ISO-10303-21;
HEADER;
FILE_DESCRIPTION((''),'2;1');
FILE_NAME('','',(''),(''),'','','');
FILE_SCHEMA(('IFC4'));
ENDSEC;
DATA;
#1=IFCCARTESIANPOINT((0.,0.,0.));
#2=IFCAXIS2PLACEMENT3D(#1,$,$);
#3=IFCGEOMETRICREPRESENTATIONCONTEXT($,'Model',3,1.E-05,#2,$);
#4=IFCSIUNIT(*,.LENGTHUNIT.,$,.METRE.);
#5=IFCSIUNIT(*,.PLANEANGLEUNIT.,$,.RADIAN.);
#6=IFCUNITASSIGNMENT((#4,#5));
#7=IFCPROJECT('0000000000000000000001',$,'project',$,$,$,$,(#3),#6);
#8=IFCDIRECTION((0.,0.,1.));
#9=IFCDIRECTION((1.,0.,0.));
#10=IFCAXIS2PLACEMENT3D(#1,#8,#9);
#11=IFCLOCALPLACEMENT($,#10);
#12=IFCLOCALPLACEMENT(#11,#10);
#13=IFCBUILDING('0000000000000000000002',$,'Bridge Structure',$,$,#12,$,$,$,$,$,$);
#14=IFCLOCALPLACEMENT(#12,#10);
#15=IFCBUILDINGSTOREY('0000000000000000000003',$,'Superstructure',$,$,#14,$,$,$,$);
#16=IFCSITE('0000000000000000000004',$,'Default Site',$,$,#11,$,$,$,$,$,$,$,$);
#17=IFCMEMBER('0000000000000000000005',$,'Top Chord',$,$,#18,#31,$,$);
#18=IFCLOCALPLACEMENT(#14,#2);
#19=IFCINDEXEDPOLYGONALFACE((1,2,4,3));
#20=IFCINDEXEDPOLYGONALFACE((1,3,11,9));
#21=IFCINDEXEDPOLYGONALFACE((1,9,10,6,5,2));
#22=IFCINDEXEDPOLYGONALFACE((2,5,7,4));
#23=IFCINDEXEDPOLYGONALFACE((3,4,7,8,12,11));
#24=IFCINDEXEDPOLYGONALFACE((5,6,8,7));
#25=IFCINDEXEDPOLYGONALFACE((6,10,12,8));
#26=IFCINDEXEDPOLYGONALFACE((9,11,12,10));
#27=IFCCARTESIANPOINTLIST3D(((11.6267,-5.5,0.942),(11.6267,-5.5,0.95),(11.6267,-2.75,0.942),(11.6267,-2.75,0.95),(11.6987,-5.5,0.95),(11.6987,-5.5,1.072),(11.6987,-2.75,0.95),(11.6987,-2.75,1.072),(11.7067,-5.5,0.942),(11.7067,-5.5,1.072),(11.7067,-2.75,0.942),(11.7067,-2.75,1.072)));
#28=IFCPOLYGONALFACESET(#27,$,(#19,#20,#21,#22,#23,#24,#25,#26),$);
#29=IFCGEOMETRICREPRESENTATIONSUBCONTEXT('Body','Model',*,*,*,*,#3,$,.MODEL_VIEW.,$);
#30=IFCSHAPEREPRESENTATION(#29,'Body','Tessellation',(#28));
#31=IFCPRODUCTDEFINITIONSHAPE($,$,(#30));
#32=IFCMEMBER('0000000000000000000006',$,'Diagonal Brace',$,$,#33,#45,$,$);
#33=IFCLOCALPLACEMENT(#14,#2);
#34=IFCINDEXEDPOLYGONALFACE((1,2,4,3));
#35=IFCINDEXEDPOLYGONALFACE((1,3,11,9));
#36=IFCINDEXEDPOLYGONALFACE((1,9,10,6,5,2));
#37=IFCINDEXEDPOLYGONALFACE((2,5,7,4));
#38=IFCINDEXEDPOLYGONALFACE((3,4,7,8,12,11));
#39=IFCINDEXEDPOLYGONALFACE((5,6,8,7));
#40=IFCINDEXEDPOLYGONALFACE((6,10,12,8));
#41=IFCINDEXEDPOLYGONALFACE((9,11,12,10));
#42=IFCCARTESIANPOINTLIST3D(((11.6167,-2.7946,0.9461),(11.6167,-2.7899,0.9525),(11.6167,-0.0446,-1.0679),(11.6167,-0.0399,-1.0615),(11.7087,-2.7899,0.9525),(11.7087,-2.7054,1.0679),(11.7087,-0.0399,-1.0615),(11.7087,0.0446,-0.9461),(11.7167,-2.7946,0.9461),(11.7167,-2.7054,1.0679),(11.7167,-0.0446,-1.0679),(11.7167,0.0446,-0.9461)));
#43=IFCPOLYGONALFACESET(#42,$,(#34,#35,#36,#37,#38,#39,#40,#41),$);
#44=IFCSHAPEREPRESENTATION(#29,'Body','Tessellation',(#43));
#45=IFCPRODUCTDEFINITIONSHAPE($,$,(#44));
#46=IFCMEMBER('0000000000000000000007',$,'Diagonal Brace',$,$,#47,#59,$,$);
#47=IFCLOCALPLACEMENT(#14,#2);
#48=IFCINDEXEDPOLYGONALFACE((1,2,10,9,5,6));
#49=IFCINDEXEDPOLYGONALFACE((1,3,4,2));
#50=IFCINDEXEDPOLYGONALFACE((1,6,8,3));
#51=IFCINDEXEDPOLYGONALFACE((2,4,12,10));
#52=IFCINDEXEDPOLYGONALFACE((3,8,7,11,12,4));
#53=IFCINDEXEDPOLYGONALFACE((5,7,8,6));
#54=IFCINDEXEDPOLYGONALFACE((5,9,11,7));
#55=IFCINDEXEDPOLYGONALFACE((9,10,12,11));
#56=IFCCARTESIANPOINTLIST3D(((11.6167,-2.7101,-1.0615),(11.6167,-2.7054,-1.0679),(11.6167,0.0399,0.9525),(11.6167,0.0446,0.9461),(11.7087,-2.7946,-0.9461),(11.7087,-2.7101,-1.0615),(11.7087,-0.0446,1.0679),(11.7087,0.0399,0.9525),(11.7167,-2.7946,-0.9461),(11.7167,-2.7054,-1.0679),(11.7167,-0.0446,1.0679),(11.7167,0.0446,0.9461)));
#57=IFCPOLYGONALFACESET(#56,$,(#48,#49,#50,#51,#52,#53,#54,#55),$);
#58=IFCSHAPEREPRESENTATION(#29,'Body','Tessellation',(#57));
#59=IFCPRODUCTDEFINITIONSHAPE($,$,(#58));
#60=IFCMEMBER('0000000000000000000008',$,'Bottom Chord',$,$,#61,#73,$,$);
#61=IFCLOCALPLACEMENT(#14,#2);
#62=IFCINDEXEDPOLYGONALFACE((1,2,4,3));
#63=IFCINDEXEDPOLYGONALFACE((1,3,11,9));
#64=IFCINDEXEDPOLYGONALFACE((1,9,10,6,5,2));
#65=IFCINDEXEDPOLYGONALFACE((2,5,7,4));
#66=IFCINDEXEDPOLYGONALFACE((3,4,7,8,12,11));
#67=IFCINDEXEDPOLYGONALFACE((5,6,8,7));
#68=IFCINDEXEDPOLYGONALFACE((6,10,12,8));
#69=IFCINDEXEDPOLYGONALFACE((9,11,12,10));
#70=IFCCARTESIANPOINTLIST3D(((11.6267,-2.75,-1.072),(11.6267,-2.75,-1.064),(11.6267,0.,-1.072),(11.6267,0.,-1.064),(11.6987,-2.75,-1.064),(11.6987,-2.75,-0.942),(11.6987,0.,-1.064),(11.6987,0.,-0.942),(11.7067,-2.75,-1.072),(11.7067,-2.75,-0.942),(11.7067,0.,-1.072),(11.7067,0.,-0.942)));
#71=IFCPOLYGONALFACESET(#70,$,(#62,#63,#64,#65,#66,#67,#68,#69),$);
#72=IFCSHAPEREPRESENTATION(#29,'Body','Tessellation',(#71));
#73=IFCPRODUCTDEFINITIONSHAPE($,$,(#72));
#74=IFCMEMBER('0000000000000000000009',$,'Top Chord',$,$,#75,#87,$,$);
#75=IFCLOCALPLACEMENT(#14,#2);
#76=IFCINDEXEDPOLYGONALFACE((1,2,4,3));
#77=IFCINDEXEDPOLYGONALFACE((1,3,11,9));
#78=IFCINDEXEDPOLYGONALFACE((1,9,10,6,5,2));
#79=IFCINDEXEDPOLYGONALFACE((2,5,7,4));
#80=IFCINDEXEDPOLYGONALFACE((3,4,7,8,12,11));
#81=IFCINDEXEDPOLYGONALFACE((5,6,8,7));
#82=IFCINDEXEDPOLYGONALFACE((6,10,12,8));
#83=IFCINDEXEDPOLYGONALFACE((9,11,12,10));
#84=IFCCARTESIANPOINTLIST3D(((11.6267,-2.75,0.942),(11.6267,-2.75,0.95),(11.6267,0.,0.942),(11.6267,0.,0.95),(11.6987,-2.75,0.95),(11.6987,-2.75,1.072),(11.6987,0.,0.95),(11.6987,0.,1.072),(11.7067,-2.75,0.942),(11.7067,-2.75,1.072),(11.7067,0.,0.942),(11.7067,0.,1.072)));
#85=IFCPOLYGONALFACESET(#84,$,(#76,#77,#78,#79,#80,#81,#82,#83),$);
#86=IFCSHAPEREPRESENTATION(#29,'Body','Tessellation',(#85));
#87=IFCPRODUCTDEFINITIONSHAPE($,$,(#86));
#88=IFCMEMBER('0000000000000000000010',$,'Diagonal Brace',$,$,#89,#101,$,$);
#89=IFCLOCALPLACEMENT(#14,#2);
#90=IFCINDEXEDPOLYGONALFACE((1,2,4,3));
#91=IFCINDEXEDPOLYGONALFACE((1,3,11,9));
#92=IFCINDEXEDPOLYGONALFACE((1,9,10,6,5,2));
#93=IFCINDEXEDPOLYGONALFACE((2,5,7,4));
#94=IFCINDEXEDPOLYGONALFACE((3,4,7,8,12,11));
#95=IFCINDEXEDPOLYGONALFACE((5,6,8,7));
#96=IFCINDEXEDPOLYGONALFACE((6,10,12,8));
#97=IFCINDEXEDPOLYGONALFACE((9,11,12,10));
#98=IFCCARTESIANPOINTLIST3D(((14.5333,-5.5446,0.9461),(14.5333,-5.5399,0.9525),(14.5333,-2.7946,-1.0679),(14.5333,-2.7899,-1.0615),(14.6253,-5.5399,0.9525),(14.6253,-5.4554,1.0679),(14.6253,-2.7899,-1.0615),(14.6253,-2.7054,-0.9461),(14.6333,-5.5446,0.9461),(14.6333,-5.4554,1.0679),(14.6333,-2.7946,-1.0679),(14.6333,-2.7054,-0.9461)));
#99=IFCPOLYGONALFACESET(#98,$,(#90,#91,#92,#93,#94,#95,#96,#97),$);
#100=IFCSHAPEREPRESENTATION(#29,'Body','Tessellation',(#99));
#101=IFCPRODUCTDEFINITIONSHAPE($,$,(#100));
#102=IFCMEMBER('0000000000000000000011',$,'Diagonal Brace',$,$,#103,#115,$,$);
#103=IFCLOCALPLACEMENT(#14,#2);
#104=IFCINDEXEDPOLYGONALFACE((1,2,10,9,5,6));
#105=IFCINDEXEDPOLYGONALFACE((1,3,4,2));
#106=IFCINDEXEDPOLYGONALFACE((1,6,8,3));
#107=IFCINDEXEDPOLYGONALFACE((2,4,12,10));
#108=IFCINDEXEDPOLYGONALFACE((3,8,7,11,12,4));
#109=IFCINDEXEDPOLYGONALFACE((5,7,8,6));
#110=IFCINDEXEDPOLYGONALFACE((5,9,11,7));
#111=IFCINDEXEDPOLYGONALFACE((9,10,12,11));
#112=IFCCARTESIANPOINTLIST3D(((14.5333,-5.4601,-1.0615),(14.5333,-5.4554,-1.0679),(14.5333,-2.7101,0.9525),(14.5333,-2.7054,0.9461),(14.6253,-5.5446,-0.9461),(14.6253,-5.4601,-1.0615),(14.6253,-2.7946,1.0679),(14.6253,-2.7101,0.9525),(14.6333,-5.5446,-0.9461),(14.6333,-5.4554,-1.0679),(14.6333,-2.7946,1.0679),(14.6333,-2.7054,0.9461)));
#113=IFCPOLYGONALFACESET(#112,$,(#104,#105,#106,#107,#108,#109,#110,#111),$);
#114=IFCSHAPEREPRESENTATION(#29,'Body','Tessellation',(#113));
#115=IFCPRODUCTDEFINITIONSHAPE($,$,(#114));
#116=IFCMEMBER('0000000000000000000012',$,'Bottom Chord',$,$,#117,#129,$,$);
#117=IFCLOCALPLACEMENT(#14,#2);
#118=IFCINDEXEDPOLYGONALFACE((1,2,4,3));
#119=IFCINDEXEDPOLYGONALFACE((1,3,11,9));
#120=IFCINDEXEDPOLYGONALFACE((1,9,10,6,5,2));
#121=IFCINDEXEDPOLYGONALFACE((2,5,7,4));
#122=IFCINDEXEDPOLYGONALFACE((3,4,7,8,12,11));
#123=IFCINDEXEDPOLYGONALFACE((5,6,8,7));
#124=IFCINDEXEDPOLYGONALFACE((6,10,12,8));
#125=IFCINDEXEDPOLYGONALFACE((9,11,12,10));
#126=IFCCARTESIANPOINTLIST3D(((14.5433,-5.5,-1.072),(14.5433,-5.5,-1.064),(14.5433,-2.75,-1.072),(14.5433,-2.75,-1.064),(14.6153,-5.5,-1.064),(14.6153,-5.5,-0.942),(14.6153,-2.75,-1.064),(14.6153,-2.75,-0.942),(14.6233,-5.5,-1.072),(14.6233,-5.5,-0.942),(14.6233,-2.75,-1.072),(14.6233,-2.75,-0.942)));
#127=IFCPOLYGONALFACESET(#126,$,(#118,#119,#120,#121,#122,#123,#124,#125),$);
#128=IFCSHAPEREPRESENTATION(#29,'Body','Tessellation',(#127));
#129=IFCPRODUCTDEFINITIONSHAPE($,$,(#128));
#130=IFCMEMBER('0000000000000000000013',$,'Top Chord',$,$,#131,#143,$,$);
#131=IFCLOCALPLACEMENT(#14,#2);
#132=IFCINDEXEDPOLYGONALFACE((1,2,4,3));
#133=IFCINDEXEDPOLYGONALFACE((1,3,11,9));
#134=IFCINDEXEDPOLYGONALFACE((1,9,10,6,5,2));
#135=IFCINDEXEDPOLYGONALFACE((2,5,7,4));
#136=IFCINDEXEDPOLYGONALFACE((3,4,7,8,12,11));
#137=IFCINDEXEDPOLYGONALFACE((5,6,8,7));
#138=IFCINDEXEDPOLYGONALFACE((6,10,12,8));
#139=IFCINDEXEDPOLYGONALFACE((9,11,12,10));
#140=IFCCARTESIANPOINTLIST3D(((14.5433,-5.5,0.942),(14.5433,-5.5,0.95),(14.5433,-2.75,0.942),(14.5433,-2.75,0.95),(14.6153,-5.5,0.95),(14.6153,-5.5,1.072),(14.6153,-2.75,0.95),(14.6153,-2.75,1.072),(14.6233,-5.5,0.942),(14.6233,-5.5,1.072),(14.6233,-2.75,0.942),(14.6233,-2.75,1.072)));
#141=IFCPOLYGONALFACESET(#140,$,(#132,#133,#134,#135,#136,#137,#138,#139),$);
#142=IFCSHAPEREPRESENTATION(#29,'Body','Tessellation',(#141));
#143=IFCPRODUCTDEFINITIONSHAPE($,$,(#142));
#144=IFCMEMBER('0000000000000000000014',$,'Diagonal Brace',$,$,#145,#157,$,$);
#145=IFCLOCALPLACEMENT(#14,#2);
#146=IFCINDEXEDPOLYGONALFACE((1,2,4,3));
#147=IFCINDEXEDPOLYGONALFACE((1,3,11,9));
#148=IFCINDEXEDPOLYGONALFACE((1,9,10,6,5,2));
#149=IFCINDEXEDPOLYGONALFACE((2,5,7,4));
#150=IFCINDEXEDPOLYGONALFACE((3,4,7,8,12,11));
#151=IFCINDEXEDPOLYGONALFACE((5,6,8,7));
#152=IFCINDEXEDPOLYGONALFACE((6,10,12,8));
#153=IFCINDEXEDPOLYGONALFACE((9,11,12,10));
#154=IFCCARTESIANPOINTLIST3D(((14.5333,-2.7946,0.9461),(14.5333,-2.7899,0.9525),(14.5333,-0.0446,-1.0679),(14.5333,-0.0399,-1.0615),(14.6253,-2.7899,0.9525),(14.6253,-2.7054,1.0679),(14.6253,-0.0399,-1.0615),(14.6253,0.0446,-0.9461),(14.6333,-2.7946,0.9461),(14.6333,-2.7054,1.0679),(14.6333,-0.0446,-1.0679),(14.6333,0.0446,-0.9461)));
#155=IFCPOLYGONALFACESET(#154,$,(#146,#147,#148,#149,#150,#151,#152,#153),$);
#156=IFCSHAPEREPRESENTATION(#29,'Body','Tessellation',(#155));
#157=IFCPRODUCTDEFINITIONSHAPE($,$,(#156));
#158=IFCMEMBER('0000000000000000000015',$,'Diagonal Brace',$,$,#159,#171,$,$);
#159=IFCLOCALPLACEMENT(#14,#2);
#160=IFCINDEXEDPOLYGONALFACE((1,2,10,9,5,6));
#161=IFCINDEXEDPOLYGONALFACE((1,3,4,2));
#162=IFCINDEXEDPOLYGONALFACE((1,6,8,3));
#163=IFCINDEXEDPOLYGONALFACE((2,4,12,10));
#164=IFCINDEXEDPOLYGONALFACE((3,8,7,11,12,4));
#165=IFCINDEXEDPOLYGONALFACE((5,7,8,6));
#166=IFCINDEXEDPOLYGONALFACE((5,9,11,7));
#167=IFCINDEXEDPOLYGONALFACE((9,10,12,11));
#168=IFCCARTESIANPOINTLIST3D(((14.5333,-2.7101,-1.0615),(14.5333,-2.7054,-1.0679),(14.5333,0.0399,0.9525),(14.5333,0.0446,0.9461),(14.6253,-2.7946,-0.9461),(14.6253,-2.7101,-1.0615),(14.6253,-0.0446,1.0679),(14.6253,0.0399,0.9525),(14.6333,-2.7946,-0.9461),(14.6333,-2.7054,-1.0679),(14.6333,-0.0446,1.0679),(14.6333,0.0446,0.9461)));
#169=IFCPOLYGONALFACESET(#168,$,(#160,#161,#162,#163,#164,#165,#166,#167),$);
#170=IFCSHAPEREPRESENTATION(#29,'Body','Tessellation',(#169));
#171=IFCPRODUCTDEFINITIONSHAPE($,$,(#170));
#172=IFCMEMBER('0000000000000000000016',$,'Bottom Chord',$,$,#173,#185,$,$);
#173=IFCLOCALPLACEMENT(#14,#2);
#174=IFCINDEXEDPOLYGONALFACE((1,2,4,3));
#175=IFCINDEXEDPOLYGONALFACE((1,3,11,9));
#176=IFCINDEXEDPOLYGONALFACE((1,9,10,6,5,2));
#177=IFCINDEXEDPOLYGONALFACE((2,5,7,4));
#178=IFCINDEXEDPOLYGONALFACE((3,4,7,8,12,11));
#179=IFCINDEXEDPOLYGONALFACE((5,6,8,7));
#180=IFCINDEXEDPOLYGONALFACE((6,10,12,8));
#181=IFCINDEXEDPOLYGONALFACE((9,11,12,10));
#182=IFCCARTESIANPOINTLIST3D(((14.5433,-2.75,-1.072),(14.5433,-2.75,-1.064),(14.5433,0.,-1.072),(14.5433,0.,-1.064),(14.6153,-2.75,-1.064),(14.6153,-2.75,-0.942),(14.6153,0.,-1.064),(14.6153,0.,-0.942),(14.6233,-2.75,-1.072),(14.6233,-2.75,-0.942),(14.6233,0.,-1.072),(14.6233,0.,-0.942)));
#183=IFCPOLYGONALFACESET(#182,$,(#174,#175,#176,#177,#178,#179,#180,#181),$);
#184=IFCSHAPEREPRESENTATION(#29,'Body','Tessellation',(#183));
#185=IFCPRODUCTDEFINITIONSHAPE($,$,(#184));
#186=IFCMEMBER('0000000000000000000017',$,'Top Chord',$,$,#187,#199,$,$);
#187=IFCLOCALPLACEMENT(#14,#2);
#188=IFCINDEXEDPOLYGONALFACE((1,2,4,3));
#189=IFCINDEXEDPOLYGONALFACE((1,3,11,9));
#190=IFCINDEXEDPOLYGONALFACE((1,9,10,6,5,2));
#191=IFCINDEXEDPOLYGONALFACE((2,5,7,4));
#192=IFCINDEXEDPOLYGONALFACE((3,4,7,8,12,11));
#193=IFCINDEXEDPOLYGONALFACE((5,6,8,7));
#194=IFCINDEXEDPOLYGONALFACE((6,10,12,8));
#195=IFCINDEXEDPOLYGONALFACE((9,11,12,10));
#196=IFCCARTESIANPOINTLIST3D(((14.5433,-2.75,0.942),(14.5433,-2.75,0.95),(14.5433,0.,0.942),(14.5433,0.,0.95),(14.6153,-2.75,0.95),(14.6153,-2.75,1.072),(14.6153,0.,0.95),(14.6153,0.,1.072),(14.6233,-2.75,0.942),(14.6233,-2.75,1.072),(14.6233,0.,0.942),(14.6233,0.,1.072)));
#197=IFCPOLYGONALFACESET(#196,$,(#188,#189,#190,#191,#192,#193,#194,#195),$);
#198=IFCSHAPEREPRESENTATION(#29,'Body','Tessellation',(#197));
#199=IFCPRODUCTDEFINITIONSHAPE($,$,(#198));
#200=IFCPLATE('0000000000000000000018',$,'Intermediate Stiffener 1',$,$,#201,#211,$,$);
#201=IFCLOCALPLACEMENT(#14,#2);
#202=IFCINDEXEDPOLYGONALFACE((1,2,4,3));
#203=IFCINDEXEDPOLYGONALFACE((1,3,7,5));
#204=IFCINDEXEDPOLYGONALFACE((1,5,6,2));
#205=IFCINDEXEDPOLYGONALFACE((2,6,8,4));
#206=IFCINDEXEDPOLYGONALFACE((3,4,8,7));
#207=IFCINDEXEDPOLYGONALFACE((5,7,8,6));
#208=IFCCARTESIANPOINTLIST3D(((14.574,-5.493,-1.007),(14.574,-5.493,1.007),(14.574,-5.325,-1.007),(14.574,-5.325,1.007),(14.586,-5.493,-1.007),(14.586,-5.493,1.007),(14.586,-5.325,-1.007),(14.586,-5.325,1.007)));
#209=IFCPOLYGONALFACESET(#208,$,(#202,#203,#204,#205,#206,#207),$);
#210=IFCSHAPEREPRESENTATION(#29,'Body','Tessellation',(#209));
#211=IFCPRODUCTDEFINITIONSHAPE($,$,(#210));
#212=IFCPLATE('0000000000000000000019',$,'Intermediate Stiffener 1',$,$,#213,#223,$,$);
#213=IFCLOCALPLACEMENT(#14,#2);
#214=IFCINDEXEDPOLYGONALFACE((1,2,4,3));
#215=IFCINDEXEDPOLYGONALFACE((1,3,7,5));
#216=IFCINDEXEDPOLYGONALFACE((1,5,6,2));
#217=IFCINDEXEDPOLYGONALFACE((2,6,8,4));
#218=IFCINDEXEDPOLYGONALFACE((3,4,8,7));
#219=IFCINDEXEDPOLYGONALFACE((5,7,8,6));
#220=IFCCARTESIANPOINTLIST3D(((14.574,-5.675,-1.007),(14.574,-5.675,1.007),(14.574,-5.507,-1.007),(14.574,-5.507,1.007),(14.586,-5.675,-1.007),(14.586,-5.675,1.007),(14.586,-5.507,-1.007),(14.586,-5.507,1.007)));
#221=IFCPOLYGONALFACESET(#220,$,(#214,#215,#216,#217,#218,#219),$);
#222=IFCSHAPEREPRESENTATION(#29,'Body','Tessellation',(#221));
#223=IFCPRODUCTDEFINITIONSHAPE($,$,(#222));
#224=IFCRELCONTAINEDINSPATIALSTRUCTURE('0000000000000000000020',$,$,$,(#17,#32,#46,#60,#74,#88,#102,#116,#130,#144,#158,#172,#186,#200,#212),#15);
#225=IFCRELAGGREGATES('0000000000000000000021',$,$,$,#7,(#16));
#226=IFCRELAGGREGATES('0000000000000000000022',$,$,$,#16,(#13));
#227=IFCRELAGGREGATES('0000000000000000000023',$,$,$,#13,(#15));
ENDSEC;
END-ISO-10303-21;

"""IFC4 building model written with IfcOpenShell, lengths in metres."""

from ifc_helpers import new_model, si_unit, frame, origin, origin_with_axes, origin_2d_with_axis, place, context, subcontext, project, spatial, rectangle, l_section, extrude, element, save


model = new_model("IFC4")

# Units and contexts
model_context = context("Model", 3, precision=1e-05, world=origin())
body_context = subcontext(model_context, "Body", "Model", "MODEL_VIEW")
ifc_project = project(units=[si_unit("LENGTHUNIT", "METRE"), si_unit("PLANEANGLEUNIT", "RADIAN")], contexts=[model_context])

# Site, building, storey
site_placement = place(None, origin_with_axes())
site = spatial("IfcSite", under=ifc_project, at=site_placement, Name="Default Site")
building_placement = place(site_placement, origin_with_axes())
building = spatial("IfcBuilding", under=site, at=building_placement, Name="Bridge Structure")
storey_placement = place(building_placement, origin_with_axes())
storey = spatial("IfcBuildingStorey", under=building, at=storey_placement, Name="Superstructure")

# Members
member_placement = place(storey_placement, frame((11.6667, -5.5, 1.007), z_axis=(0.0, 1.0, 0.0), x_axis=(-1.0, 0.0, 0.0)))
element("IfcMember", 1, at=member_placement, inside=storey, Name="Top Chord", context=body_context, shape_type="SweptSolid", body=[
    extrude(l_section(Depth=0.13, Width=0.08, Thickness=0.008, at=origin_2d_with_axis()), origin_with_axes(), (0.0, 0.0, 1.0), 2.75),
])
for number, where, z_axis, x_axis, name in (
    (2, (11.6667, -2.75, 1.007), (0.0, 0.806778, -0.590855), (-1.0, 0.0, 0.0), "Diagonal Brace"),
    (3, (11.6667, -2.75, -1.007), (0.0, 0.806778, 0.590855), (-1.0, 0.0, 0.0), "Diagonal Brace"),
):
    element("IfcMember", number, at=place(storey_placement, frame(where, z_axis=z_axis, x_axis=x_axis)), inside=storey, Name=name, context=body_context, shape_type="SweptSolid", body=[
        extrude(l_section(Depth=0.151, Width=0.1, Thickness=0.008, at=origin_2d_with_axis()), origin_with_axes(), (0.0, 0.0, 1.0), 3.4086),
    ])
for number, where, z_axis, x_axis, name in (
    (4, (11.6667, -2.75, -1.007), (0.0, 1.0, 0.0), (-1.0, 0.0, 0.0), "Bottom Chord"),
    (5, (11.6667, -2.75, 1.007), (0.0, 1.0, 0.0), (-1.0, 0.0, 0.0), "Top Chord"),
):
    element("IfcMember", number, at=place(storey_placement, frame(where, z_axis=z_axis, x_axis=x_axis)), inside=storey, Name=name, context=body_context, shape_type="SweptSolid", body=[
        extrude(l_section(Depth=0.13, Width=0.08, Thickness=0.008, at=origin_2d_with_axis()), origin_with_axes(), (0.0, 0.0, 1.0), 2.75),
    ])
for number, where, z_axis, x_axis, name in (
    (6, (14.5833, -5.5, 1.007), (0.0, 0.806778, -0.590855), (-1.0, 0.0, 0.0), "Diagonal Brace"),
    (7, (14.5833, -5.5, -1.007), (0.0, 0.806778, 0.590855), (-1.0, 0.0, 0.0), "Diagonal Brace"),
):
    element("IfcMember", number, at=place(storey_placement, frame(where, z_axis=z_axis, x_axis=x_axis)), inside=storey, Name=name, context=body_context, shape_type="SweptSolid", body=[
        extrude(l_section(Depth=0.151, Width=0.1, Thickness=0.008, at=origin_2d_with_axis()), origin_with_axes(), (0.0, 0.0, 1.0), 3.4086),
    ])
for number, where, z_axis, x_axis, name in (
    (8, (14.5833, -5.5, -1.007), (0.0, 1.0, 0.0), (-1.0, 0.0, 0.0), "Bottom Chord"),
    (9, (14.5833, -5.5, 1.007), (0.0, 1.0, 0.0), (-1.0, 0.0, 0.0), "Top Chord"),
):
    element("IfcMember", number, at=place(storey_placement, frame(where, z_axis=z_axis, x_axis=x_axis)), inside=storey, Name=name, context=body_context, shape_type="SweptSolid", body=[
        extrude(l_section(Depth=0.13, Width=0.08, Thickness=0.008, at=origin_2d_with_axis()), origin_with_axes(), (0.0, 0.0, 1.0), 2.75),
    ])
for number, where, z_axis, x_axis, name in (
    (10, (14.5833, -2.75, 1.007), (0.0, 0.806778, -0.590855), (-1.0, 0.0, 0.0), "Diagonal Brace"),
    (11, (14.5833, -2.75, -1.007), (0.0, 0.806778, 0.590855), (-1.0, 0.0, 0.0), "Diagonal Brace"),
):
    element("IfcMember", number, at=place(storey_placement, frame(where, z_axis=z_axis, x_axis=x_axis)), inside=storey, Name=name, context=body_context, shape_type="SweptSolid", body=[
        extrude(l_section(Depth=0.151, Width=0.1, Thickness=0.008, at=origin_2d_with_axis()), origin_with_axes(), (0.0, 0.0, 1.0), 3.4086),
    ])
for number, where, z_axis, x_axis, name in (
    (12, (14.5833, -2.75, -1.007), (0.0, 1.0, 0.0), (-1.0, 0.0, 0.0), "Bottom Chord"),
    (13, (14.5833, -2.75, 1.007), (0.0, 1.0, 0.0), (-1.0, 0.0, 0.0), "Top Chord"),
):
    element("IfcMember", number, at=place(storey_placement, frame(where, z_axis=z_axis, x_axis=x_axis)), inside=storey, Name=name, context=body_context, shape_type="SweptSolid", body=[
        extrude(l_section(Depth=0.13, Width=0.08, Thickness=0.008, at=origin_2d_with_axis()), origin_with_axes(), (0.0, 0.0, 1.0), 2.75),
    ])

# Plates
for number, where, z_axis, x_axis, name in (
    (14, (14.58, -5.409, -1.007), (0.0, 0.0, 1.0), (1.0, 0.0, 0.0), "Intermediate Stiffener 1"),
    (15, (14.58, -5.591, -1.007), (0.0, 0.0, 1.0), (1.0, 0.0, 0.0), "Intermediate Stiffener 1"),
):
    element("IfcPlate", number, at=place(storey_placement, frame(where, z_axis=z_axis, x_axis=x_axis)), inside=storey, Name=name, context=body_context, shape_type="SweptSolid", body=[
        extrude(rectangle(XDim=0.012, YDim=0.168, at=origin_2d_with_axis()), origin_with_axes(), (0.0, 0.0, 1.0), 2.014),
    ])

save(model, "model.ifc")
